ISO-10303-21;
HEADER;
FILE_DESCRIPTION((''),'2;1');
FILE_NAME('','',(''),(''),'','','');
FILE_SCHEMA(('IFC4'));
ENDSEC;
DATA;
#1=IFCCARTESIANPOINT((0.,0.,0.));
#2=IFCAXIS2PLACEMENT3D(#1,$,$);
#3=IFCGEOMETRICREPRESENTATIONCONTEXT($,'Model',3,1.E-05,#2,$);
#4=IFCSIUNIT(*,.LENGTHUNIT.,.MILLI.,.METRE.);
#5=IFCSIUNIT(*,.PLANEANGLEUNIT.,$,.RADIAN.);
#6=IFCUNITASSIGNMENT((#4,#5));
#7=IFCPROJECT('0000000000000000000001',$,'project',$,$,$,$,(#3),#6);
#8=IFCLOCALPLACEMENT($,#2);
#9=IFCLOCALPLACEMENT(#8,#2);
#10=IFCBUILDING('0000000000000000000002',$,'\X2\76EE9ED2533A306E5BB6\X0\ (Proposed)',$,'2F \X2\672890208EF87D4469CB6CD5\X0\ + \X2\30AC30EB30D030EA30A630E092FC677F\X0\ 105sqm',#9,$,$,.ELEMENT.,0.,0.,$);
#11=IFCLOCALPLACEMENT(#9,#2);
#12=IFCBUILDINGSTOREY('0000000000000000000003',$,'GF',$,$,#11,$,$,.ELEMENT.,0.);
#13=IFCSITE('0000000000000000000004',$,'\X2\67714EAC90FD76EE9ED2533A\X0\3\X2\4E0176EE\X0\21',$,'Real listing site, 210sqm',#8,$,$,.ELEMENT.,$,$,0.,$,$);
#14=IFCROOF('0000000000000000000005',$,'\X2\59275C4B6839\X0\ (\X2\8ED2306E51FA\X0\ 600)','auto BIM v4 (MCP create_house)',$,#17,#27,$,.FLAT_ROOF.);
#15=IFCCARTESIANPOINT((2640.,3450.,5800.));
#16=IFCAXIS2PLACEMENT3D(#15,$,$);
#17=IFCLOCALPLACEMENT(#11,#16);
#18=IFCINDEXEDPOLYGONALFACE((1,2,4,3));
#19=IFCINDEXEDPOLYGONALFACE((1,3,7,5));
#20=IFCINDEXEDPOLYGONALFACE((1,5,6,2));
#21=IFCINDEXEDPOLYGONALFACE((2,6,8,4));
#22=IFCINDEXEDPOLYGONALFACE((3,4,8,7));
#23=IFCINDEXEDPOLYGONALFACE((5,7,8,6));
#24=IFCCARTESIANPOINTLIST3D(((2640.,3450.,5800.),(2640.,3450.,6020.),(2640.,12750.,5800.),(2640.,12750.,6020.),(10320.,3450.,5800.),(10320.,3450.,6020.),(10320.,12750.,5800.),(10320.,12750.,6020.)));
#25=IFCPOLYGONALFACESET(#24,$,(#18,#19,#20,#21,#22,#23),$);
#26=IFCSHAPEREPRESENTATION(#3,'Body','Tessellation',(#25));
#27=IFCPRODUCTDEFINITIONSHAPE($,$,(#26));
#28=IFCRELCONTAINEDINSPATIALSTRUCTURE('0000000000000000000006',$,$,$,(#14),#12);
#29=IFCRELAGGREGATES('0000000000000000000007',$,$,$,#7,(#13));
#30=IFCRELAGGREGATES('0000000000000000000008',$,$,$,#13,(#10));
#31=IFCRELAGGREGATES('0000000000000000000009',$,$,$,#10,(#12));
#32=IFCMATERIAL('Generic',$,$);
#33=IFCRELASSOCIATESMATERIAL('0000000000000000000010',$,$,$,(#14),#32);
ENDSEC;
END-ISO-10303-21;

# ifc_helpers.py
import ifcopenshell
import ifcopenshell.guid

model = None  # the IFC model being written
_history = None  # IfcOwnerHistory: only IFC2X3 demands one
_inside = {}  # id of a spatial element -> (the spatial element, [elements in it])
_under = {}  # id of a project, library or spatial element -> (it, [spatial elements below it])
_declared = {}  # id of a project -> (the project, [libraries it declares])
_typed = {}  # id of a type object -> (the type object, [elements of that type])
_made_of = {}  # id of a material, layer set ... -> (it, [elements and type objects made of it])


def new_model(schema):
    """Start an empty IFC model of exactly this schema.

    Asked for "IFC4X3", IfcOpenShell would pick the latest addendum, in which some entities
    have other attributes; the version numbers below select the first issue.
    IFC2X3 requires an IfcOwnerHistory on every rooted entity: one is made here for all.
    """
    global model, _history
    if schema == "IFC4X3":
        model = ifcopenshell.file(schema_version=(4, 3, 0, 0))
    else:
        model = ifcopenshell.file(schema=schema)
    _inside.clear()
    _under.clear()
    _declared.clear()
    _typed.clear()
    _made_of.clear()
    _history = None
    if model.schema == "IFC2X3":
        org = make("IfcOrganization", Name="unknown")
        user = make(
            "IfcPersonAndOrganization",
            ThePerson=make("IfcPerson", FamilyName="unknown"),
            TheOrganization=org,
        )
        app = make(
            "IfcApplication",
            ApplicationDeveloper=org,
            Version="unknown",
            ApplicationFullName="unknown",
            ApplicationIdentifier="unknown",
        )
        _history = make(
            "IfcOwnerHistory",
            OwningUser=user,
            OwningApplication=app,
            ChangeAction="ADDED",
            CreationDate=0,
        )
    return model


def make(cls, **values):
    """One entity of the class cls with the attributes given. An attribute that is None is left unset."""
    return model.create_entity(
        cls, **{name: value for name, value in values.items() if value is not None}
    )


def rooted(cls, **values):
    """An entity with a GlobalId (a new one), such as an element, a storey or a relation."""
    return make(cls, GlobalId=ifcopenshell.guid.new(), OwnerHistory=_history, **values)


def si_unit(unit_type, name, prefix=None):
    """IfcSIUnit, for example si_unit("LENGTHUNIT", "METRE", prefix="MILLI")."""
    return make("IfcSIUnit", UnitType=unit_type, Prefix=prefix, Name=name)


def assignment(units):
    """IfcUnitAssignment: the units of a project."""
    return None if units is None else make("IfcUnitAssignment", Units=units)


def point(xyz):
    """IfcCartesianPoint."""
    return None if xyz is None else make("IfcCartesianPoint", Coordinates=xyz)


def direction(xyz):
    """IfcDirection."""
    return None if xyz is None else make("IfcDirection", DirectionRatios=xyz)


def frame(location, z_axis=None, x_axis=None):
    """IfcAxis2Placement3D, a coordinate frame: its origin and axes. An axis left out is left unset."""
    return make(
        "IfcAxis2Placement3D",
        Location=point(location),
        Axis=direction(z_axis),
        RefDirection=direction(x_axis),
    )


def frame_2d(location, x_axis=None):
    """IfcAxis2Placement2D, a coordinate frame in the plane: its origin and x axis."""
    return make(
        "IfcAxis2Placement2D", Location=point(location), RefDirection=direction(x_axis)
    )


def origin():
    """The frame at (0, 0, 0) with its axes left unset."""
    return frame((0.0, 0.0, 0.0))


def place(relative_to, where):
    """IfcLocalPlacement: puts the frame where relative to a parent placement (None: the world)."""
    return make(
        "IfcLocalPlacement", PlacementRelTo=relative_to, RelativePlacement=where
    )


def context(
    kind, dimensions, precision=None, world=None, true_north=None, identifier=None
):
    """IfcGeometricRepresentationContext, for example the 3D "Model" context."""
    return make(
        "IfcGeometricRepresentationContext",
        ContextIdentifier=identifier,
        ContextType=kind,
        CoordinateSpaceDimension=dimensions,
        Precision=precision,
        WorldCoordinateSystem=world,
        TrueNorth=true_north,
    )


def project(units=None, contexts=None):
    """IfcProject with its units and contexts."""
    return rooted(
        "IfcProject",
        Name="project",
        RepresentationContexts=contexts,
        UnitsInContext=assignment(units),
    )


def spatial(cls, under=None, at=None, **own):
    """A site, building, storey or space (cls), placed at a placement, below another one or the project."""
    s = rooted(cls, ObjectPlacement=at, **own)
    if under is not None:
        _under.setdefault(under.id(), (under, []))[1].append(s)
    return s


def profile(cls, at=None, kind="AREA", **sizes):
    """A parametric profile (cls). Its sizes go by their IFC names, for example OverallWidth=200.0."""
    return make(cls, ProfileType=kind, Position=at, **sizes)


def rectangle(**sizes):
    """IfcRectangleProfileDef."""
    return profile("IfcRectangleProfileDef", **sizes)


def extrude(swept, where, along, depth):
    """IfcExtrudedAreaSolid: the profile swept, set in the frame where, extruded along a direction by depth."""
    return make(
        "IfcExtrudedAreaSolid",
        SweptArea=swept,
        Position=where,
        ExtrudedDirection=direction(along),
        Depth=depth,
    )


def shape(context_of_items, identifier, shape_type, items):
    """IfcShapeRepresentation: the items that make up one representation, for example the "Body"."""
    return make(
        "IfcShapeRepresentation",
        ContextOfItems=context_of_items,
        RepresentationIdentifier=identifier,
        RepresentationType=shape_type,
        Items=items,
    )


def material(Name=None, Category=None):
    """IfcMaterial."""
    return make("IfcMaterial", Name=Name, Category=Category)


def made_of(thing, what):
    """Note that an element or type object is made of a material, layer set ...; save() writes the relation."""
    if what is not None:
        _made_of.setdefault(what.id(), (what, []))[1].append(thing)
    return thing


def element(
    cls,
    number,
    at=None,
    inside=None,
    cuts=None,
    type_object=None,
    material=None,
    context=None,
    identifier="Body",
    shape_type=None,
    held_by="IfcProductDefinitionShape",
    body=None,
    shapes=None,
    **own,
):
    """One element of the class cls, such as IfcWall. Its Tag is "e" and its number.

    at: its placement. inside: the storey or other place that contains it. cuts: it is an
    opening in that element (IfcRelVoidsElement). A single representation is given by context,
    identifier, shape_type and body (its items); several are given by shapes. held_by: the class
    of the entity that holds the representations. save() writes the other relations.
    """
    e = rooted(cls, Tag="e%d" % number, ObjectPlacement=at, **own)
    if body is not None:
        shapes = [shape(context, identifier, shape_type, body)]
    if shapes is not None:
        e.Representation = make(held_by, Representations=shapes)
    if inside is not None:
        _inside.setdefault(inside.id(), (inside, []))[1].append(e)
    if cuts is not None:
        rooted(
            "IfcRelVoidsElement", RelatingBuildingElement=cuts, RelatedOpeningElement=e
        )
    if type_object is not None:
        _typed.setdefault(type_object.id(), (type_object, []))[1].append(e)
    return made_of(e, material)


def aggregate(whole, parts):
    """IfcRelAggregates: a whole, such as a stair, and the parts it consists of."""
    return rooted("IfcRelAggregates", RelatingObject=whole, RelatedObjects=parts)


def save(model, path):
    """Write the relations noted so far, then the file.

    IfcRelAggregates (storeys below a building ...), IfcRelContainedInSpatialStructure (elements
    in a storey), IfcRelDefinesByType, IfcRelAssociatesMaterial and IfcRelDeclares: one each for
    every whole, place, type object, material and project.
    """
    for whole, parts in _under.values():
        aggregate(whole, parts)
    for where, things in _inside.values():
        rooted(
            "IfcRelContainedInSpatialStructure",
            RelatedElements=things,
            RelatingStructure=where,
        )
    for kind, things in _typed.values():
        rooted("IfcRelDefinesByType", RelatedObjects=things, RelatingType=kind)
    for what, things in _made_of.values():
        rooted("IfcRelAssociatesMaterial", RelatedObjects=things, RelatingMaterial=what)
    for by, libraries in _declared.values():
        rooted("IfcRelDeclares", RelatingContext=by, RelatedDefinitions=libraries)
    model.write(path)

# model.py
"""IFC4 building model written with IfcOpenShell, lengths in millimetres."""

from ifc_helpers import new_model, si_unit, frame, frame_2d, origin, place, context, project, spatial, rectangle, extrude, material, element, save


model = new_model("IFC4")

# Units and contexts
model_context = context("Model", 3, precision=1e-05, world=origin())
ifc_project = project(units=[si_unit("LENGTHUNIT", "METRE", prefix="MILLI"), si_unit("PLANEANGLEUNIT", "RADIAN")], contexts=[model_context])

# Site, building, storey
site_placement = place(None, origin())
site = spatial("IfcSite", under=ifc_project, at=site_placement, Name="東京都目黒区3丁目21", ObjectType="Real listing site, 210sqm", CompositionType="ELEMENT", RefElevation=0.0)
building_placement = place(site_placement, origin())
building = spatial("IfcBuilding", under=site, at=building_placement, Name="目黒区の家 (Proposed)", ObjectType="2F 木造軸組構法 + ガルバリウム鋼板 105sqm", CompositionType="ELEMENT", ElevationOfRefHeight=0.0, ElevationOfTerrain=0.0)
storey_placement = place(building_placement, origin())
storey = spatial("IfcBuildingStorey", under=building, at=storey_placement, Name="GF", CompositionType="ELEMENT", Elevation=0.0)

# Shared definitions
ifc_material = material(Name="Generic")

# Roof
roof_placement = place(storey_placement, frame((2640.0, 3450.0, 5800.0)))
element("IfcRoof", 1, at=roof_placement, inside=storey, material=ifc_material, Name="大屋根 (軒の出 600)", Description="auto BIM v4 (MCP create_house)", PredefinedType="FLAT_ROOF", context=model_context, shape_type="SweptSolid", body=[
    extrude(rectangle(XDim=7680.0, YDim=9300.0, at=frame_2d((3840.0, 4650.0))), frame((2640.0, 3450.0, 5800.0)), (0.0, 0.0, 1.0), 220.0),
])

save(model, "model.ifc")
